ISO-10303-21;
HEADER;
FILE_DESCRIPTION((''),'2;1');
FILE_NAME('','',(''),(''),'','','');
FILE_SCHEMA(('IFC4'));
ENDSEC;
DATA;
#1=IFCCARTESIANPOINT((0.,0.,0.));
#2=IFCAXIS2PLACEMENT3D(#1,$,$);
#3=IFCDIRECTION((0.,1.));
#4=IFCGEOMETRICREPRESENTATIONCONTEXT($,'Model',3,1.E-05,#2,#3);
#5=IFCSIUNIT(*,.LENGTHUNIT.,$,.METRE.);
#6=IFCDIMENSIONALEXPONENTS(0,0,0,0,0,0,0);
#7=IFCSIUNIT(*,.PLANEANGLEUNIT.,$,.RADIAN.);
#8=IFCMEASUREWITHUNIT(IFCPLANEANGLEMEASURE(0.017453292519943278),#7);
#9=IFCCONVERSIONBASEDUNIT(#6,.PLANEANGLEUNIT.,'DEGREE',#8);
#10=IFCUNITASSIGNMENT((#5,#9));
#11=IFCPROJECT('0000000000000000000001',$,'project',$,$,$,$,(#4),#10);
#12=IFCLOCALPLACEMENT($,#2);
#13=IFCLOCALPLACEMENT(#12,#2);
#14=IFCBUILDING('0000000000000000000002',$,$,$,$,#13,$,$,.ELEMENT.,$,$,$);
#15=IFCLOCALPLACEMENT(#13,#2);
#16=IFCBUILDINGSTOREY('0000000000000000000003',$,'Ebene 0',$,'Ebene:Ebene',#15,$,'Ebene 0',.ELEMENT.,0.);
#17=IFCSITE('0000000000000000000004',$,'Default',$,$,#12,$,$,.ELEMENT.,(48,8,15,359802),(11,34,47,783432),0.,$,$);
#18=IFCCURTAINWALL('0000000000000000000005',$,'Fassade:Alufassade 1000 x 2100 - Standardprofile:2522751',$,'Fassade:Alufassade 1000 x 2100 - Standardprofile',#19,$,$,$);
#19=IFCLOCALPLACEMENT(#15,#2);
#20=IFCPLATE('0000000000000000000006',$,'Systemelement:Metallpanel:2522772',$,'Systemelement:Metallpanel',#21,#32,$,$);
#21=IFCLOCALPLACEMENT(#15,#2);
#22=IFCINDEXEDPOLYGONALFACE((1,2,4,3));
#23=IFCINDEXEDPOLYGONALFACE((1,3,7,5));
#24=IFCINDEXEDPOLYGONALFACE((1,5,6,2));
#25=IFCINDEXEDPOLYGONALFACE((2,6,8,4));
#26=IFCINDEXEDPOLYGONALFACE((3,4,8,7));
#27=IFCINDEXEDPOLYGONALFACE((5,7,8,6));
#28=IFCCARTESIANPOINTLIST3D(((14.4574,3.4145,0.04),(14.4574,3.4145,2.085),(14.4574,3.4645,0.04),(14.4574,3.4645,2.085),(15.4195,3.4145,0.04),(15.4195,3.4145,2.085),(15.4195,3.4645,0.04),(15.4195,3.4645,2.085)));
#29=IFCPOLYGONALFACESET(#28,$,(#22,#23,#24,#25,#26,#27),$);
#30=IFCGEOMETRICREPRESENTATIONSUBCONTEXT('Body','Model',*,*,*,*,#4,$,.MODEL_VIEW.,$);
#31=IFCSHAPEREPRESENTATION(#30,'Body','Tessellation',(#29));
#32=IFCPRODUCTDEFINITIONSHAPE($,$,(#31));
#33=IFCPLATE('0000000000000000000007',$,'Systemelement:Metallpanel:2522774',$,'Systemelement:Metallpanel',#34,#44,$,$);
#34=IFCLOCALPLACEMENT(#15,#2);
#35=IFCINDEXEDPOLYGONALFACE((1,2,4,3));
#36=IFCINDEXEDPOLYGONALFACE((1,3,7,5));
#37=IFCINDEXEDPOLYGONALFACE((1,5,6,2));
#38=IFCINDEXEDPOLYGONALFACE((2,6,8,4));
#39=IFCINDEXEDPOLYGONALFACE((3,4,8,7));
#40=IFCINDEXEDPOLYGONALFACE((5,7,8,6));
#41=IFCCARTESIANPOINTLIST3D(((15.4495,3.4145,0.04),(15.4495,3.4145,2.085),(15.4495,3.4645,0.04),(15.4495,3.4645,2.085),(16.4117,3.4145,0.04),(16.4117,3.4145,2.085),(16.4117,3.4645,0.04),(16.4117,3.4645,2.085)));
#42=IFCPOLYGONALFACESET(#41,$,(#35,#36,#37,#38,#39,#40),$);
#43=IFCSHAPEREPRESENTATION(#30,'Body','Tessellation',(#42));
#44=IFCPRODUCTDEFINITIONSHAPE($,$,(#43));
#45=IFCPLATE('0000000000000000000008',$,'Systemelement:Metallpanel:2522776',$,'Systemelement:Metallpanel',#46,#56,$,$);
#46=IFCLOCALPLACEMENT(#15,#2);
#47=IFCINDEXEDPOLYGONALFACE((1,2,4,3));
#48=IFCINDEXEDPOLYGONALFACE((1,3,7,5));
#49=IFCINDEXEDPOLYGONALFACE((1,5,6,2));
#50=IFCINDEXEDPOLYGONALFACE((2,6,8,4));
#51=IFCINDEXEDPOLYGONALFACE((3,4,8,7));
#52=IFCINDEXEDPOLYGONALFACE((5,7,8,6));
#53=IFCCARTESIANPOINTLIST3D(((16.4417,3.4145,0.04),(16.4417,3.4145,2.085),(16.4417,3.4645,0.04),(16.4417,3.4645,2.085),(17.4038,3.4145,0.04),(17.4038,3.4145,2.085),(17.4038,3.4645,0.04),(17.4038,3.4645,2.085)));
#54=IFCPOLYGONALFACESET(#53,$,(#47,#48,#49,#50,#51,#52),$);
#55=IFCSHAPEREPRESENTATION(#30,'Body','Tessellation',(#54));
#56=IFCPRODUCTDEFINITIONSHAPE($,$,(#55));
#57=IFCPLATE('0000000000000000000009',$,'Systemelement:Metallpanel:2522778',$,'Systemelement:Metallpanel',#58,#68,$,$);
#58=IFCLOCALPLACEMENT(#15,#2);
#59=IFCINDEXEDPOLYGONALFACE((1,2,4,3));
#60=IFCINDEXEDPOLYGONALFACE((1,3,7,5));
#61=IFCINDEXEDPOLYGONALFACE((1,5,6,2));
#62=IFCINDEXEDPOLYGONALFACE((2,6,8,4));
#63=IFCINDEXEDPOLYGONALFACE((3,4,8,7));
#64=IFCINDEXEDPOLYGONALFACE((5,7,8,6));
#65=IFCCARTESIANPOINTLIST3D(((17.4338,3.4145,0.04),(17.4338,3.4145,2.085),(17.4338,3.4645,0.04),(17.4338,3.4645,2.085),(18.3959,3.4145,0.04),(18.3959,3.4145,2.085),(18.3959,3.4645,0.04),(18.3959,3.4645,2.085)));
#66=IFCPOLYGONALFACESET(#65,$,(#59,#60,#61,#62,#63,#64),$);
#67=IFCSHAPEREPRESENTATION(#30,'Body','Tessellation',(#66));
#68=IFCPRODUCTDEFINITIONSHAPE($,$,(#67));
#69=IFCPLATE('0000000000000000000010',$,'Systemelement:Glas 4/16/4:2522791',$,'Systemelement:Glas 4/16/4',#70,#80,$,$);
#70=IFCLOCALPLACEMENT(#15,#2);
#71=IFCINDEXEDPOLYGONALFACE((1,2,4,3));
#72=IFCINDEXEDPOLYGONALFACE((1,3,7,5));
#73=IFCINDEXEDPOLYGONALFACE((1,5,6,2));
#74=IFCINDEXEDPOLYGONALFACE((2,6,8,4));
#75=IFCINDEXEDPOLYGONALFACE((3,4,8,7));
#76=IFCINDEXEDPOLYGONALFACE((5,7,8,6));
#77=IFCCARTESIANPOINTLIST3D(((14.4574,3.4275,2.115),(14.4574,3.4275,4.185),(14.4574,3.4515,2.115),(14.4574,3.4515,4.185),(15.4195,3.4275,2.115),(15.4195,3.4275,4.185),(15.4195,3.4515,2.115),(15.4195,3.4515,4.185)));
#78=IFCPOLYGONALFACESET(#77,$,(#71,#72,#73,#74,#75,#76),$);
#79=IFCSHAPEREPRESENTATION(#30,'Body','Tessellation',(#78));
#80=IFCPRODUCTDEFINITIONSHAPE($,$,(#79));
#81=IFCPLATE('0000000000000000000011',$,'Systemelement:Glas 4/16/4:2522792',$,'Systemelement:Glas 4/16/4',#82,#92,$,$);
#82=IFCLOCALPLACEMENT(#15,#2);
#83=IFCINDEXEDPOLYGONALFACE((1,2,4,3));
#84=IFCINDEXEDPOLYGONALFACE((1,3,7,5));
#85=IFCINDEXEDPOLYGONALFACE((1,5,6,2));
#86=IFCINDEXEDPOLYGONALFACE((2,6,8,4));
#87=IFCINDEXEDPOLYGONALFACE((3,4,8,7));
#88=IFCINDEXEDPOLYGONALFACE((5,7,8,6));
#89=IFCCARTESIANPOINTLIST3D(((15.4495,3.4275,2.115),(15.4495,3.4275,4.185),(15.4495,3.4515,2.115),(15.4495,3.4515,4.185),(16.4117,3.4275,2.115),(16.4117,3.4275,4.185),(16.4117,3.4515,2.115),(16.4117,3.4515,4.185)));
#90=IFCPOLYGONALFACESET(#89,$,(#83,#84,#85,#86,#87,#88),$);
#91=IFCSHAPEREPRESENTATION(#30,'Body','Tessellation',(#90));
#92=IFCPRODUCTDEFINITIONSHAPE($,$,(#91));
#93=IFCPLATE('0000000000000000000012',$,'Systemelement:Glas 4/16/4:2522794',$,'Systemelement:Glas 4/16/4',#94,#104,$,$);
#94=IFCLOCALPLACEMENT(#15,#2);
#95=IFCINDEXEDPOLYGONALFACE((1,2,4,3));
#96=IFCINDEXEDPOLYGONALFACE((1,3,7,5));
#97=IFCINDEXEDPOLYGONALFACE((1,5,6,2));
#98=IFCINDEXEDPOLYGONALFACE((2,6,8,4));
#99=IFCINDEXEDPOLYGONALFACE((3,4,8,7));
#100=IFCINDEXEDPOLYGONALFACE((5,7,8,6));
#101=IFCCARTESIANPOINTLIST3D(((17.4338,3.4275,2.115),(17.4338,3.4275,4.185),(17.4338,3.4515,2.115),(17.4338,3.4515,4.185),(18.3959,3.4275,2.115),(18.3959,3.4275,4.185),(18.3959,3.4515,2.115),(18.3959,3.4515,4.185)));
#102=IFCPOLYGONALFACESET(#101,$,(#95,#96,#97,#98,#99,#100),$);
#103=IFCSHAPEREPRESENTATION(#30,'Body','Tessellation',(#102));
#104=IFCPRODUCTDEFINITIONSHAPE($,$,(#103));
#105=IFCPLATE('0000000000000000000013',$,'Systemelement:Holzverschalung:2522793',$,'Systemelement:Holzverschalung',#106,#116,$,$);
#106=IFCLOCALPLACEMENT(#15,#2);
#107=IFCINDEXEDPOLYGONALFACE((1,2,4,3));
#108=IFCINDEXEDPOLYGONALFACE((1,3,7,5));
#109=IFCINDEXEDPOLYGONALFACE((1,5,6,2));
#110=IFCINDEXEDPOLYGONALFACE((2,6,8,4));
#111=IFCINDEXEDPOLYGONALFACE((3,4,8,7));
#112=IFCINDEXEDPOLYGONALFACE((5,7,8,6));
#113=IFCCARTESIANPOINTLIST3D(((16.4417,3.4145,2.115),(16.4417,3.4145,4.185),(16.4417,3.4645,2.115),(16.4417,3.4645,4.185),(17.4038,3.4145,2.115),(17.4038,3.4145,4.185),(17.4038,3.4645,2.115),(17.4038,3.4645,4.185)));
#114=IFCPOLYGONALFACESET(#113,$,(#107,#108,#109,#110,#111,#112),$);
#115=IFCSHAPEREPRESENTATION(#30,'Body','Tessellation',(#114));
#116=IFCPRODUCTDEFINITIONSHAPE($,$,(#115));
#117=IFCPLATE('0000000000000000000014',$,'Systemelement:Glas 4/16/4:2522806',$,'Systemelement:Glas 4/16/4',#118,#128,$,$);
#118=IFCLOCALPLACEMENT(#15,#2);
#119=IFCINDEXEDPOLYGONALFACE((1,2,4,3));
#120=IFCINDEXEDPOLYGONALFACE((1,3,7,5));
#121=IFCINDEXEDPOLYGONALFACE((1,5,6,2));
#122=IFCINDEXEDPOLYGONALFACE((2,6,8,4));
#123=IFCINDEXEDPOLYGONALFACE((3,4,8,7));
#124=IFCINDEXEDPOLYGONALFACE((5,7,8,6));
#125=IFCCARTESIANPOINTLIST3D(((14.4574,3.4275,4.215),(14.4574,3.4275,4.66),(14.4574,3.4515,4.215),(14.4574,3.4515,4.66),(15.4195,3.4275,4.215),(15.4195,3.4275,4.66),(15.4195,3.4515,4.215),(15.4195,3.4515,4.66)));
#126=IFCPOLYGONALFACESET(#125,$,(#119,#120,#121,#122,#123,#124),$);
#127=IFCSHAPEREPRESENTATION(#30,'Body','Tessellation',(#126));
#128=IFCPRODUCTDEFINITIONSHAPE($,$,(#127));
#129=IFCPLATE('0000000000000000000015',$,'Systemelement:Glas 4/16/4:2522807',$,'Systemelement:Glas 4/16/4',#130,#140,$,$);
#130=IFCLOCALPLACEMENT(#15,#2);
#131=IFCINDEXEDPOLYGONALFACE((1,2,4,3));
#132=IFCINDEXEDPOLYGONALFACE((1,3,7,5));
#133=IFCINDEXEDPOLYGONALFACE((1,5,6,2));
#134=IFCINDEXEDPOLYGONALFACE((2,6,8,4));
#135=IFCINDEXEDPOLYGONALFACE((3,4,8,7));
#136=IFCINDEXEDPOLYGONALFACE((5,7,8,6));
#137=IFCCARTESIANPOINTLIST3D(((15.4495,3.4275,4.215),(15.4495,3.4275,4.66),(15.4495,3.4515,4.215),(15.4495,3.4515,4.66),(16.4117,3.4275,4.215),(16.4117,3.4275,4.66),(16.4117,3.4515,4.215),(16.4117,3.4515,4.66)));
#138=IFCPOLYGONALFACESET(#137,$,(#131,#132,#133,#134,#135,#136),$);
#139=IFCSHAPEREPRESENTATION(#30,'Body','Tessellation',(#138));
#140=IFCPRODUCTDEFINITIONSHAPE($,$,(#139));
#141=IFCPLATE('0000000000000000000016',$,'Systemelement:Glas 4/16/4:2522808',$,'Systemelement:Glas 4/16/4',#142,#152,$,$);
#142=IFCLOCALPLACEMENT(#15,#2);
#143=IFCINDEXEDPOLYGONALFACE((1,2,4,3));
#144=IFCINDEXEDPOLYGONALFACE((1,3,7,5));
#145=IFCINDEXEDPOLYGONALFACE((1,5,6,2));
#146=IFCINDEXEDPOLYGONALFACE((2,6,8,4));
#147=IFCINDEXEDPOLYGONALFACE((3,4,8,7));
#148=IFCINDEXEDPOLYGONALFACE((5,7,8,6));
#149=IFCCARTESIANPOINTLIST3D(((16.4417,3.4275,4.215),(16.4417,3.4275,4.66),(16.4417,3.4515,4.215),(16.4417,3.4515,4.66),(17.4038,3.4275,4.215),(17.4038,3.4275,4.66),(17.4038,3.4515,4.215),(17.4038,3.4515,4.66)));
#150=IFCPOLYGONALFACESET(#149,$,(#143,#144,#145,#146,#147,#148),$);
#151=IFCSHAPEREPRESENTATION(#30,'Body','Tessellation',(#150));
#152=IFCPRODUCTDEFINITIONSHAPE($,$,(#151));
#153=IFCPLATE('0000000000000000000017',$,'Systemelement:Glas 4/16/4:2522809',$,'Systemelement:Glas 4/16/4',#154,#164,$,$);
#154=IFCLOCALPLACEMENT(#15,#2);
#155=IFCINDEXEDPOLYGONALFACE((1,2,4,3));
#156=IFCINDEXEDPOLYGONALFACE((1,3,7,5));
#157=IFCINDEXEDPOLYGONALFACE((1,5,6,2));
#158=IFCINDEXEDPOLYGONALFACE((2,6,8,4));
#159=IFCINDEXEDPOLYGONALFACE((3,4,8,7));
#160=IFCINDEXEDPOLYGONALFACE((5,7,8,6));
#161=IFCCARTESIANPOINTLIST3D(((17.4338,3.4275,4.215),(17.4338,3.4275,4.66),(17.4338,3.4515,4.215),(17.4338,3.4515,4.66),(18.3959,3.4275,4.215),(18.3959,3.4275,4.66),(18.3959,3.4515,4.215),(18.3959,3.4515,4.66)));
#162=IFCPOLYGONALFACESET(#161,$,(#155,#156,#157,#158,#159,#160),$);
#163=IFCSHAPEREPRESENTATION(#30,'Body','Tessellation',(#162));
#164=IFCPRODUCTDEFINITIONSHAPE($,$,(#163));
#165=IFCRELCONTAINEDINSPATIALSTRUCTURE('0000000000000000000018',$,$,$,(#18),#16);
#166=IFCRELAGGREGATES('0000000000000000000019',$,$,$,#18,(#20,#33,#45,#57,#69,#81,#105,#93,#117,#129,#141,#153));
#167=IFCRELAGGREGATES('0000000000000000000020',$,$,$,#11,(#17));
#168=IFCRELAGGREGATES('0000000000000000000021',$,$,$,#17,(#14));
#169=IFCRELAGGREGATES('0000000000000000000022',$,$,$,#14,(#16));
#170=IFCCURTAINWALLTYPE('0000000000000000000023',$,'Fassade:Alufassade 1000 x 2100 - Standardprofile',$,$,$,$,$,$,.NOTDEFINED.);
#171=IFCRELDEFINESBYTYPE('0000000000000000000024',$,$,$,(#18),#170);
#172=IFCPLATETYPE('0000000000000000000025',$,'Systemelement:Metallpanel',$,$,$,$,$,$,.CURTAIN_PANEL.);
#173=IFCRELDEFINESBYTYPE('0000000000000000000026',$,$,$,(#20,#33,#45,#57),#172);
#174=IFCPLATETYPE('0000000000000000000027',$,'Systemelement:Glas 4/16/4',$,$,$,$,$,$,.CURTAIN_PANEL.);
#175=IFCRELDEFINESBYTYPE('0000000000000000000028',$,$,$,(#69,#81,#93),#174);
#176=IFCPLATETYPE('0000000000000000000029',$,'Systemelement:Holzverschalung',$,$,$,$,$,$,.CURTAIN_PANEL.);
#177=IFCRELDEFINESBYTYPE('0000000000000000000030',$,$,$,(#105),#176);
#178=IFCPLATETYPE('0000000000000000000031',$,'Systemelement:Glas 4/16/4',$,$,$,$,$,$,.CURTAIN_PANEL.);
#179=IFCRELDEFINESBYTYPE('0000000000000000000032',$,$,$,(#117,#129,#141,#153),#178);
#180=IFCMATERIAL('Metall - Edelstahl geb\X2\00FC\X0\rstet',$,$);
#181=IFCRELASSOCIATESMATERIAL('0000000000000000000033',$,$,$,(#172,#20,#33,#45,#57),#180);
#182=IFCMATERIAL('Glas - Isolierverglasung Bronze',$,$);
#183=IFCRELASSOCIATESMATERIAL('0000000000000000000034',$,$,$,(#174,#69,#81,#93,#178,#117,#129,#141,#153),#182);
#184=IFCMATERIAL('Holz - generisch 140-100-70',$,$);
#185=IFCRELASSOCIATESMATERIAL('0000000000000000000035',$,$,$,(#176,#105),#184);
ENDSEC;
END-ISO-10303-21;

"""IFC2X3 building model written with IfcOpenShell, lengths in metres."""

from ifc_helpers import new_model, entity, si_unit, converted_unit, direction, frame, origin, origin_2d_with_axis, place, context, subcontext, project, spatial, rectangle, extrude, source, transform, mapped, material, type_object, type_shapes, element, aggregate, save


model = new_model("IFC2X3")

# Units and contexts
model_context = context("Model", 3, precision=1e-05, world=origin(), true_north=direction((0.0, 1.0)))
body_context = subcontext(model_context, "Body", "Model", "MODEL_VIEW")
ifc_project = project(units=[si_unit("LENGTHUNIT", "METRE"), converted_unit("PLANEANGLEUNIT", "DEGREE", entity("IfcPlaneAngleMeasure", 0.017453292519943278), si_unit("PLANEANGLEUNIT", "RADIAN"), dimensions=[0, 0, 0, 0, 0, 0, 0])], contexts=[model_context])

# Site, building, storey
site_placement = place(None, origin())
site = spatial("IfcSite", under=ifc_project, at=site_placement, Name="Default", CompositionType="ELEMENT", RefLatitude=(48, 8, 15, 359802), RefLongitude=(11, 34, 47, 783432), RefElevation=0.0)
building_placement = place(site_placement, origin())
building = spatial("IfcBuilding", under=site, at=building_placement, CompositionType="ELEMENT")
storey_placement = place(building_placement, origin())
storey = spatial("IfcBuildingStorey", under=building, at=storey_placement, Name="Ebene 0", ObjectType="Ebene:Ebene", LongName="Ebene 0", CompositionType="ELEMENT", Elevation=0.0)

# Curtain wall, plates
curtain_wall_type = type_object("IfcCurtainWallType", Name="Fassade:Alufassade 1000 x 2100 - Standardprofile", PredefinedType="NOTDEFINED")
curtain_wall_placement = place(storey_placement, origin())
curtain_wall = element("IfcCurtainWall", 1, at=curtain_wall_placement, inside=storey, type_object=curtain_wall_type, Name="Fassade:Alufassade 1000 x 2100 - Standardprofile:2522751", ObjectType="Fassade:Alufassade 1000 x 2100 - Standardprofile")
ifc_material_1 = material(Name="Metall - Edelstahl gebürstet")
plate_type_1 = type_object("IfcPlateType", Name="Systemelement:Metallpanel", PredefinedType="CURTAIN_PANEL", material=ifc_material_1)
shared_shape_1 = source(origin(), body_context, "Body", "SweptSolid", [
    extrude(rectangle(XDim=0.05, YDim=0.9621, at=origin_2d_with_axis()), frame((0.0, 0.0, 0.0), z_axis=(0.0, 0.0, 1.0), x_axis=(0.0, 1.0, 0.0)), (0.0, 0.0, 1.0), 2.045),
])
type_shapes(plate_type_1, [shared_shape_1])
plate_1_placement = place(curtain_wall_placement, frame((14.9384, 3.4395, 0.04)))
plate_1 = element("IfcPlate", 2, at=plate_1_placement, type_object=plate_type_1, material=ifc_material_1, Name="Systemelement:Metallpanel:2522772", ObjectType="Systemelement:Metallpanel", context=body_context, shape_type="MappedRepresentation", body=[
    mapped(shared_shape_1, transform((0.0, 0.0, 0.0), scale=1.0)),
])
plate_2_placement = place(curtain_wall_placement, frame((15.9306, 3.4395, 0.04)))
plate_2 = element("IfcPlate", 3, at=plate_2_placement, type_object=plate_type_1, material=ifc_material_1, Name="Systemelement:Metallpanel:2522774", ObjectType="Systemelement:Metallpanel", context=body_context, shape_type="MappedRepresentation", body=[
    mapped(shared_shape_1, transform((0.0, 0.0, 0.0), scale=1.0)),
])
plate_3_placement = place(curtain_wall_placement, frame((16.9227, 3.4395, 0.04)))
plate_3 = element("IfcPlate", 4, at=plate_3_placement, type_object=plate_type_1, material=ifc_material_1, Name="Systemelement:Metallpanel:2522776", ObjectType="Systemelement:Metallpanel", context=body_context, shape_type="MappedRepresentation", body=[
    mapped(shared_shape_1, transform((0.0, 0.0, 0.0), scale=1.0)),
])
plate_4_placement = place(curtain_wall_placement, frame((17.9149, 3.4395, 0.04)))
plate_4 = element("IfcPlate", 5, at=plate_4_placement, type_object=plate_type_1, material=ifc_material_1, Name="Systemelement:Metallpanel:2522778", ObjectType="Systemelement:Metallpanel", context=body_context, shape_type="MappedRepresentation", body=[
    mapped(shared_shape_1, transform((0.0, 0.0, 0.0), scale=1.0)),
])
ifc_material_2 = material(Name="Glas - Isolierverglasung Bronze")
plate_type_2 = type_object("IfcPlateType", Name="Systemelement:Glas 4/16/4", PredefinedType="CURTAIN_PANEL", material=ifc_material_2)
shared_shape_2 = source(origin(), body_context, "Body", "SweptSolid", [
    extrude(rectangle(XDim=0.024, YDim=0.9621, at=origin_2d_with_axis()), frame((0.0, 0.0, 0.0), z_axis=(0.0, 0.0, 1.0), x_axis=(0.0, 1.0, 0.0)), (0.0, 0.0, 1.0), 2.07),
])
type_shapes(plate_type_2, [shared_shape_2])
plate_5_placement = place(curtain_wall_placement, frame((14.9384, 3.4395, 2.115)))
plate_5 = element("IfcPlate", 6, at=plate_5_placement, type_object=plate_type_2, material=ifc_material_2, Name="Systemelement:Glas 4/16/4:2522791", ObjectType="Systemelement:Glas 4/16/4", context=body_context, shape_type="MappedRepresentation", body=[
    mapped(shared_shape_2, transform((0.0, 0.0, 0.0), scale=1.0)),
])
plate_6_placement = place(curtain_wall_placement, frame((15.9306, 3.4395, 2.115)))
plate_6 = element("IfcPlate", 7, at=plate_6_placement, type_object=plate_type_2, material=ifc_material_2, Name="Systemelement:Glas 4/16/4:2522792", ObjectType="Systemelement:Glas 4/16/4", context=body_context, shape_type="MappedRepresentation", body=[
    mapped(shared_shape_2, transform((0.0, 0.0, 0.0), scale=1.0)),
])
plate_7_placement = place(curtain_wall_placement, frame((17.9149, 3.4395, 2.115)))
plate_7 = element("IfcPlate", 8, at=plate_7_placement, type_object=plate_type_2, material=ifc_material_2, Name="Systemelement:Glas 4/16/4:2522794", ObjectType="Systemelement:Glas 4/16/4", context=body_context, shape_type="MappedRepresentation", body=[
    mapped(shared_shape_2, transform((0.0, 0.0, 0.0), scale=1.0)),
])
ifc_material_3 = material(Name="Holz - generisch 140-100-70")
plate_type_3 = type_object("IfcPlateType", Name="Systemelement:Holzverschalung", PredefinedType="CURTAIN_PANEL", material=ifc_material_3)
shared_shape_3 = source(origin(), body_context, "Body", "SweptSolid", [
    extrude(rectangle(XDim=0.05, YDim=0.9621, at=origin_2d_with_axis()), frame((0.0, 0.0, 0.0), z_axis=(0.0, 0.0, 1.0), x_axis=(0.0, 1.0, 0.0)), (0.0, 0.0, 1.0), 2.07),
])
type_shapes(plate_type_3, [shared_shape_3])
plate_8_placement = place(curtain_wall_placement, frame((16.9227, 3.4395, 2.115)))
plate_8 = element("IfcPlate", 9, at=plate_8_placement, type_object=plate_type_3, material=ifc_material_3, Name="Systemelement:Holzverschalung:2522793", ObjectType="Systemelement:Holzverschalung", context=body_context, shape_type="MappedRepresentation", body=[
    mapped(shared_shape_3, transform((0.0, 0.0, 0.0), scale=1.0)),
])
plate_type_4 = type_object("IfcPlateType", Name="Systemelement:Glas 4/16/4", PredefinedType="CURTAIN_PANEL", material=ifc_material_2)
shared_shape_4 = source(origin(), body_context, "Body", "SweptSolid", [
    extrude(rectangle(XDim=0.024, YDim=0.9621, at=origin_2d_with_axis()), frame((0.0, 0.0, 0.0), z_axis=(0.0, 0.0, 1.0), x_axis=(0.0, 1.0, 0.0)), (0.0, 0.0, 1.0), 0.445),
])
type_shapes(plate_type_4, [shared_shape_4])
plate_9_placement = place(curtain_wall_placement, frame((14.9384, 3.4395, 4.215)))
plate_9 = element("IfcPlate", 10, at=plate_9_placement, type_object=plate_type_4, material=ifc_material_2, Name="Systemelement:Glas 4/16/4:2522806", ObjectType="Systemelement:Glas 4/16/4", context=body_context, shape_type="MappedRepresentation", body=[
    mapped(shared_shape_4, transform((0.0, 0.0, 0.0), scale=1.0)),
])
plate_10_placement = place(curtain_wall_placement, frame((15.9306, 3.4395, 4.215)))
plate_10 = element("IfcPlate", 11, at=plate_10_placement, type_object=plate_type_4, material=ifc_material_2, Name="Systemelement:Glas 4/16/4:2522807", ObjectType="Systemelement:Glas 4/16/4", context=body_context, shape_type="MappedRepresentation", body=[
    mapped(shared_shape_4, transform((0.0, 0.0, 0.0), scale=1.0)),
])
plate_11_placement = place(curtain_wall_placement, frame((16.9227, 3.4395, 4.215)))
plate_11 = element("IfcPlate", 12, at=plate_11_placement, type_object=plate_type_4, material=ifc_material_2, Name="Systemelement:Glas 4/16/4:2522808", ObjectType="Systemelement:Glas 4/16/4", context=body_context, shape_type="MappedRepresentation", body=[
    mapped(shared_shape_4, transform((0.0, 0.0, 0.0), scale=1.0)),
])
plate_12_placement = place(curtain_wall_placement, frame((17.9149, 3.4395, 4.215)))
plate_12 = element("IfcPlate", 13, at=plate_12_placement, type_object=plate_type_4, material=ifc_material_2, Name="Systemelement:Glas 4/16/4:2522809", ObjectType="Systemelement:Glas 4/16/4", context=body_context, shape_type="MappedRepresentation", body=[
    mapped(shared_shape_4, transform((0.0, 0.0, 0.0), scale=1.0)),
])
aggregate(curtain_wall, [plate_1, plate_2, plate_3, plate_4, plate_5, plate_6, plate_8, plate_7, plate_9, plate_10, plate_11, plate_12])

save(model, "model.ifc")
